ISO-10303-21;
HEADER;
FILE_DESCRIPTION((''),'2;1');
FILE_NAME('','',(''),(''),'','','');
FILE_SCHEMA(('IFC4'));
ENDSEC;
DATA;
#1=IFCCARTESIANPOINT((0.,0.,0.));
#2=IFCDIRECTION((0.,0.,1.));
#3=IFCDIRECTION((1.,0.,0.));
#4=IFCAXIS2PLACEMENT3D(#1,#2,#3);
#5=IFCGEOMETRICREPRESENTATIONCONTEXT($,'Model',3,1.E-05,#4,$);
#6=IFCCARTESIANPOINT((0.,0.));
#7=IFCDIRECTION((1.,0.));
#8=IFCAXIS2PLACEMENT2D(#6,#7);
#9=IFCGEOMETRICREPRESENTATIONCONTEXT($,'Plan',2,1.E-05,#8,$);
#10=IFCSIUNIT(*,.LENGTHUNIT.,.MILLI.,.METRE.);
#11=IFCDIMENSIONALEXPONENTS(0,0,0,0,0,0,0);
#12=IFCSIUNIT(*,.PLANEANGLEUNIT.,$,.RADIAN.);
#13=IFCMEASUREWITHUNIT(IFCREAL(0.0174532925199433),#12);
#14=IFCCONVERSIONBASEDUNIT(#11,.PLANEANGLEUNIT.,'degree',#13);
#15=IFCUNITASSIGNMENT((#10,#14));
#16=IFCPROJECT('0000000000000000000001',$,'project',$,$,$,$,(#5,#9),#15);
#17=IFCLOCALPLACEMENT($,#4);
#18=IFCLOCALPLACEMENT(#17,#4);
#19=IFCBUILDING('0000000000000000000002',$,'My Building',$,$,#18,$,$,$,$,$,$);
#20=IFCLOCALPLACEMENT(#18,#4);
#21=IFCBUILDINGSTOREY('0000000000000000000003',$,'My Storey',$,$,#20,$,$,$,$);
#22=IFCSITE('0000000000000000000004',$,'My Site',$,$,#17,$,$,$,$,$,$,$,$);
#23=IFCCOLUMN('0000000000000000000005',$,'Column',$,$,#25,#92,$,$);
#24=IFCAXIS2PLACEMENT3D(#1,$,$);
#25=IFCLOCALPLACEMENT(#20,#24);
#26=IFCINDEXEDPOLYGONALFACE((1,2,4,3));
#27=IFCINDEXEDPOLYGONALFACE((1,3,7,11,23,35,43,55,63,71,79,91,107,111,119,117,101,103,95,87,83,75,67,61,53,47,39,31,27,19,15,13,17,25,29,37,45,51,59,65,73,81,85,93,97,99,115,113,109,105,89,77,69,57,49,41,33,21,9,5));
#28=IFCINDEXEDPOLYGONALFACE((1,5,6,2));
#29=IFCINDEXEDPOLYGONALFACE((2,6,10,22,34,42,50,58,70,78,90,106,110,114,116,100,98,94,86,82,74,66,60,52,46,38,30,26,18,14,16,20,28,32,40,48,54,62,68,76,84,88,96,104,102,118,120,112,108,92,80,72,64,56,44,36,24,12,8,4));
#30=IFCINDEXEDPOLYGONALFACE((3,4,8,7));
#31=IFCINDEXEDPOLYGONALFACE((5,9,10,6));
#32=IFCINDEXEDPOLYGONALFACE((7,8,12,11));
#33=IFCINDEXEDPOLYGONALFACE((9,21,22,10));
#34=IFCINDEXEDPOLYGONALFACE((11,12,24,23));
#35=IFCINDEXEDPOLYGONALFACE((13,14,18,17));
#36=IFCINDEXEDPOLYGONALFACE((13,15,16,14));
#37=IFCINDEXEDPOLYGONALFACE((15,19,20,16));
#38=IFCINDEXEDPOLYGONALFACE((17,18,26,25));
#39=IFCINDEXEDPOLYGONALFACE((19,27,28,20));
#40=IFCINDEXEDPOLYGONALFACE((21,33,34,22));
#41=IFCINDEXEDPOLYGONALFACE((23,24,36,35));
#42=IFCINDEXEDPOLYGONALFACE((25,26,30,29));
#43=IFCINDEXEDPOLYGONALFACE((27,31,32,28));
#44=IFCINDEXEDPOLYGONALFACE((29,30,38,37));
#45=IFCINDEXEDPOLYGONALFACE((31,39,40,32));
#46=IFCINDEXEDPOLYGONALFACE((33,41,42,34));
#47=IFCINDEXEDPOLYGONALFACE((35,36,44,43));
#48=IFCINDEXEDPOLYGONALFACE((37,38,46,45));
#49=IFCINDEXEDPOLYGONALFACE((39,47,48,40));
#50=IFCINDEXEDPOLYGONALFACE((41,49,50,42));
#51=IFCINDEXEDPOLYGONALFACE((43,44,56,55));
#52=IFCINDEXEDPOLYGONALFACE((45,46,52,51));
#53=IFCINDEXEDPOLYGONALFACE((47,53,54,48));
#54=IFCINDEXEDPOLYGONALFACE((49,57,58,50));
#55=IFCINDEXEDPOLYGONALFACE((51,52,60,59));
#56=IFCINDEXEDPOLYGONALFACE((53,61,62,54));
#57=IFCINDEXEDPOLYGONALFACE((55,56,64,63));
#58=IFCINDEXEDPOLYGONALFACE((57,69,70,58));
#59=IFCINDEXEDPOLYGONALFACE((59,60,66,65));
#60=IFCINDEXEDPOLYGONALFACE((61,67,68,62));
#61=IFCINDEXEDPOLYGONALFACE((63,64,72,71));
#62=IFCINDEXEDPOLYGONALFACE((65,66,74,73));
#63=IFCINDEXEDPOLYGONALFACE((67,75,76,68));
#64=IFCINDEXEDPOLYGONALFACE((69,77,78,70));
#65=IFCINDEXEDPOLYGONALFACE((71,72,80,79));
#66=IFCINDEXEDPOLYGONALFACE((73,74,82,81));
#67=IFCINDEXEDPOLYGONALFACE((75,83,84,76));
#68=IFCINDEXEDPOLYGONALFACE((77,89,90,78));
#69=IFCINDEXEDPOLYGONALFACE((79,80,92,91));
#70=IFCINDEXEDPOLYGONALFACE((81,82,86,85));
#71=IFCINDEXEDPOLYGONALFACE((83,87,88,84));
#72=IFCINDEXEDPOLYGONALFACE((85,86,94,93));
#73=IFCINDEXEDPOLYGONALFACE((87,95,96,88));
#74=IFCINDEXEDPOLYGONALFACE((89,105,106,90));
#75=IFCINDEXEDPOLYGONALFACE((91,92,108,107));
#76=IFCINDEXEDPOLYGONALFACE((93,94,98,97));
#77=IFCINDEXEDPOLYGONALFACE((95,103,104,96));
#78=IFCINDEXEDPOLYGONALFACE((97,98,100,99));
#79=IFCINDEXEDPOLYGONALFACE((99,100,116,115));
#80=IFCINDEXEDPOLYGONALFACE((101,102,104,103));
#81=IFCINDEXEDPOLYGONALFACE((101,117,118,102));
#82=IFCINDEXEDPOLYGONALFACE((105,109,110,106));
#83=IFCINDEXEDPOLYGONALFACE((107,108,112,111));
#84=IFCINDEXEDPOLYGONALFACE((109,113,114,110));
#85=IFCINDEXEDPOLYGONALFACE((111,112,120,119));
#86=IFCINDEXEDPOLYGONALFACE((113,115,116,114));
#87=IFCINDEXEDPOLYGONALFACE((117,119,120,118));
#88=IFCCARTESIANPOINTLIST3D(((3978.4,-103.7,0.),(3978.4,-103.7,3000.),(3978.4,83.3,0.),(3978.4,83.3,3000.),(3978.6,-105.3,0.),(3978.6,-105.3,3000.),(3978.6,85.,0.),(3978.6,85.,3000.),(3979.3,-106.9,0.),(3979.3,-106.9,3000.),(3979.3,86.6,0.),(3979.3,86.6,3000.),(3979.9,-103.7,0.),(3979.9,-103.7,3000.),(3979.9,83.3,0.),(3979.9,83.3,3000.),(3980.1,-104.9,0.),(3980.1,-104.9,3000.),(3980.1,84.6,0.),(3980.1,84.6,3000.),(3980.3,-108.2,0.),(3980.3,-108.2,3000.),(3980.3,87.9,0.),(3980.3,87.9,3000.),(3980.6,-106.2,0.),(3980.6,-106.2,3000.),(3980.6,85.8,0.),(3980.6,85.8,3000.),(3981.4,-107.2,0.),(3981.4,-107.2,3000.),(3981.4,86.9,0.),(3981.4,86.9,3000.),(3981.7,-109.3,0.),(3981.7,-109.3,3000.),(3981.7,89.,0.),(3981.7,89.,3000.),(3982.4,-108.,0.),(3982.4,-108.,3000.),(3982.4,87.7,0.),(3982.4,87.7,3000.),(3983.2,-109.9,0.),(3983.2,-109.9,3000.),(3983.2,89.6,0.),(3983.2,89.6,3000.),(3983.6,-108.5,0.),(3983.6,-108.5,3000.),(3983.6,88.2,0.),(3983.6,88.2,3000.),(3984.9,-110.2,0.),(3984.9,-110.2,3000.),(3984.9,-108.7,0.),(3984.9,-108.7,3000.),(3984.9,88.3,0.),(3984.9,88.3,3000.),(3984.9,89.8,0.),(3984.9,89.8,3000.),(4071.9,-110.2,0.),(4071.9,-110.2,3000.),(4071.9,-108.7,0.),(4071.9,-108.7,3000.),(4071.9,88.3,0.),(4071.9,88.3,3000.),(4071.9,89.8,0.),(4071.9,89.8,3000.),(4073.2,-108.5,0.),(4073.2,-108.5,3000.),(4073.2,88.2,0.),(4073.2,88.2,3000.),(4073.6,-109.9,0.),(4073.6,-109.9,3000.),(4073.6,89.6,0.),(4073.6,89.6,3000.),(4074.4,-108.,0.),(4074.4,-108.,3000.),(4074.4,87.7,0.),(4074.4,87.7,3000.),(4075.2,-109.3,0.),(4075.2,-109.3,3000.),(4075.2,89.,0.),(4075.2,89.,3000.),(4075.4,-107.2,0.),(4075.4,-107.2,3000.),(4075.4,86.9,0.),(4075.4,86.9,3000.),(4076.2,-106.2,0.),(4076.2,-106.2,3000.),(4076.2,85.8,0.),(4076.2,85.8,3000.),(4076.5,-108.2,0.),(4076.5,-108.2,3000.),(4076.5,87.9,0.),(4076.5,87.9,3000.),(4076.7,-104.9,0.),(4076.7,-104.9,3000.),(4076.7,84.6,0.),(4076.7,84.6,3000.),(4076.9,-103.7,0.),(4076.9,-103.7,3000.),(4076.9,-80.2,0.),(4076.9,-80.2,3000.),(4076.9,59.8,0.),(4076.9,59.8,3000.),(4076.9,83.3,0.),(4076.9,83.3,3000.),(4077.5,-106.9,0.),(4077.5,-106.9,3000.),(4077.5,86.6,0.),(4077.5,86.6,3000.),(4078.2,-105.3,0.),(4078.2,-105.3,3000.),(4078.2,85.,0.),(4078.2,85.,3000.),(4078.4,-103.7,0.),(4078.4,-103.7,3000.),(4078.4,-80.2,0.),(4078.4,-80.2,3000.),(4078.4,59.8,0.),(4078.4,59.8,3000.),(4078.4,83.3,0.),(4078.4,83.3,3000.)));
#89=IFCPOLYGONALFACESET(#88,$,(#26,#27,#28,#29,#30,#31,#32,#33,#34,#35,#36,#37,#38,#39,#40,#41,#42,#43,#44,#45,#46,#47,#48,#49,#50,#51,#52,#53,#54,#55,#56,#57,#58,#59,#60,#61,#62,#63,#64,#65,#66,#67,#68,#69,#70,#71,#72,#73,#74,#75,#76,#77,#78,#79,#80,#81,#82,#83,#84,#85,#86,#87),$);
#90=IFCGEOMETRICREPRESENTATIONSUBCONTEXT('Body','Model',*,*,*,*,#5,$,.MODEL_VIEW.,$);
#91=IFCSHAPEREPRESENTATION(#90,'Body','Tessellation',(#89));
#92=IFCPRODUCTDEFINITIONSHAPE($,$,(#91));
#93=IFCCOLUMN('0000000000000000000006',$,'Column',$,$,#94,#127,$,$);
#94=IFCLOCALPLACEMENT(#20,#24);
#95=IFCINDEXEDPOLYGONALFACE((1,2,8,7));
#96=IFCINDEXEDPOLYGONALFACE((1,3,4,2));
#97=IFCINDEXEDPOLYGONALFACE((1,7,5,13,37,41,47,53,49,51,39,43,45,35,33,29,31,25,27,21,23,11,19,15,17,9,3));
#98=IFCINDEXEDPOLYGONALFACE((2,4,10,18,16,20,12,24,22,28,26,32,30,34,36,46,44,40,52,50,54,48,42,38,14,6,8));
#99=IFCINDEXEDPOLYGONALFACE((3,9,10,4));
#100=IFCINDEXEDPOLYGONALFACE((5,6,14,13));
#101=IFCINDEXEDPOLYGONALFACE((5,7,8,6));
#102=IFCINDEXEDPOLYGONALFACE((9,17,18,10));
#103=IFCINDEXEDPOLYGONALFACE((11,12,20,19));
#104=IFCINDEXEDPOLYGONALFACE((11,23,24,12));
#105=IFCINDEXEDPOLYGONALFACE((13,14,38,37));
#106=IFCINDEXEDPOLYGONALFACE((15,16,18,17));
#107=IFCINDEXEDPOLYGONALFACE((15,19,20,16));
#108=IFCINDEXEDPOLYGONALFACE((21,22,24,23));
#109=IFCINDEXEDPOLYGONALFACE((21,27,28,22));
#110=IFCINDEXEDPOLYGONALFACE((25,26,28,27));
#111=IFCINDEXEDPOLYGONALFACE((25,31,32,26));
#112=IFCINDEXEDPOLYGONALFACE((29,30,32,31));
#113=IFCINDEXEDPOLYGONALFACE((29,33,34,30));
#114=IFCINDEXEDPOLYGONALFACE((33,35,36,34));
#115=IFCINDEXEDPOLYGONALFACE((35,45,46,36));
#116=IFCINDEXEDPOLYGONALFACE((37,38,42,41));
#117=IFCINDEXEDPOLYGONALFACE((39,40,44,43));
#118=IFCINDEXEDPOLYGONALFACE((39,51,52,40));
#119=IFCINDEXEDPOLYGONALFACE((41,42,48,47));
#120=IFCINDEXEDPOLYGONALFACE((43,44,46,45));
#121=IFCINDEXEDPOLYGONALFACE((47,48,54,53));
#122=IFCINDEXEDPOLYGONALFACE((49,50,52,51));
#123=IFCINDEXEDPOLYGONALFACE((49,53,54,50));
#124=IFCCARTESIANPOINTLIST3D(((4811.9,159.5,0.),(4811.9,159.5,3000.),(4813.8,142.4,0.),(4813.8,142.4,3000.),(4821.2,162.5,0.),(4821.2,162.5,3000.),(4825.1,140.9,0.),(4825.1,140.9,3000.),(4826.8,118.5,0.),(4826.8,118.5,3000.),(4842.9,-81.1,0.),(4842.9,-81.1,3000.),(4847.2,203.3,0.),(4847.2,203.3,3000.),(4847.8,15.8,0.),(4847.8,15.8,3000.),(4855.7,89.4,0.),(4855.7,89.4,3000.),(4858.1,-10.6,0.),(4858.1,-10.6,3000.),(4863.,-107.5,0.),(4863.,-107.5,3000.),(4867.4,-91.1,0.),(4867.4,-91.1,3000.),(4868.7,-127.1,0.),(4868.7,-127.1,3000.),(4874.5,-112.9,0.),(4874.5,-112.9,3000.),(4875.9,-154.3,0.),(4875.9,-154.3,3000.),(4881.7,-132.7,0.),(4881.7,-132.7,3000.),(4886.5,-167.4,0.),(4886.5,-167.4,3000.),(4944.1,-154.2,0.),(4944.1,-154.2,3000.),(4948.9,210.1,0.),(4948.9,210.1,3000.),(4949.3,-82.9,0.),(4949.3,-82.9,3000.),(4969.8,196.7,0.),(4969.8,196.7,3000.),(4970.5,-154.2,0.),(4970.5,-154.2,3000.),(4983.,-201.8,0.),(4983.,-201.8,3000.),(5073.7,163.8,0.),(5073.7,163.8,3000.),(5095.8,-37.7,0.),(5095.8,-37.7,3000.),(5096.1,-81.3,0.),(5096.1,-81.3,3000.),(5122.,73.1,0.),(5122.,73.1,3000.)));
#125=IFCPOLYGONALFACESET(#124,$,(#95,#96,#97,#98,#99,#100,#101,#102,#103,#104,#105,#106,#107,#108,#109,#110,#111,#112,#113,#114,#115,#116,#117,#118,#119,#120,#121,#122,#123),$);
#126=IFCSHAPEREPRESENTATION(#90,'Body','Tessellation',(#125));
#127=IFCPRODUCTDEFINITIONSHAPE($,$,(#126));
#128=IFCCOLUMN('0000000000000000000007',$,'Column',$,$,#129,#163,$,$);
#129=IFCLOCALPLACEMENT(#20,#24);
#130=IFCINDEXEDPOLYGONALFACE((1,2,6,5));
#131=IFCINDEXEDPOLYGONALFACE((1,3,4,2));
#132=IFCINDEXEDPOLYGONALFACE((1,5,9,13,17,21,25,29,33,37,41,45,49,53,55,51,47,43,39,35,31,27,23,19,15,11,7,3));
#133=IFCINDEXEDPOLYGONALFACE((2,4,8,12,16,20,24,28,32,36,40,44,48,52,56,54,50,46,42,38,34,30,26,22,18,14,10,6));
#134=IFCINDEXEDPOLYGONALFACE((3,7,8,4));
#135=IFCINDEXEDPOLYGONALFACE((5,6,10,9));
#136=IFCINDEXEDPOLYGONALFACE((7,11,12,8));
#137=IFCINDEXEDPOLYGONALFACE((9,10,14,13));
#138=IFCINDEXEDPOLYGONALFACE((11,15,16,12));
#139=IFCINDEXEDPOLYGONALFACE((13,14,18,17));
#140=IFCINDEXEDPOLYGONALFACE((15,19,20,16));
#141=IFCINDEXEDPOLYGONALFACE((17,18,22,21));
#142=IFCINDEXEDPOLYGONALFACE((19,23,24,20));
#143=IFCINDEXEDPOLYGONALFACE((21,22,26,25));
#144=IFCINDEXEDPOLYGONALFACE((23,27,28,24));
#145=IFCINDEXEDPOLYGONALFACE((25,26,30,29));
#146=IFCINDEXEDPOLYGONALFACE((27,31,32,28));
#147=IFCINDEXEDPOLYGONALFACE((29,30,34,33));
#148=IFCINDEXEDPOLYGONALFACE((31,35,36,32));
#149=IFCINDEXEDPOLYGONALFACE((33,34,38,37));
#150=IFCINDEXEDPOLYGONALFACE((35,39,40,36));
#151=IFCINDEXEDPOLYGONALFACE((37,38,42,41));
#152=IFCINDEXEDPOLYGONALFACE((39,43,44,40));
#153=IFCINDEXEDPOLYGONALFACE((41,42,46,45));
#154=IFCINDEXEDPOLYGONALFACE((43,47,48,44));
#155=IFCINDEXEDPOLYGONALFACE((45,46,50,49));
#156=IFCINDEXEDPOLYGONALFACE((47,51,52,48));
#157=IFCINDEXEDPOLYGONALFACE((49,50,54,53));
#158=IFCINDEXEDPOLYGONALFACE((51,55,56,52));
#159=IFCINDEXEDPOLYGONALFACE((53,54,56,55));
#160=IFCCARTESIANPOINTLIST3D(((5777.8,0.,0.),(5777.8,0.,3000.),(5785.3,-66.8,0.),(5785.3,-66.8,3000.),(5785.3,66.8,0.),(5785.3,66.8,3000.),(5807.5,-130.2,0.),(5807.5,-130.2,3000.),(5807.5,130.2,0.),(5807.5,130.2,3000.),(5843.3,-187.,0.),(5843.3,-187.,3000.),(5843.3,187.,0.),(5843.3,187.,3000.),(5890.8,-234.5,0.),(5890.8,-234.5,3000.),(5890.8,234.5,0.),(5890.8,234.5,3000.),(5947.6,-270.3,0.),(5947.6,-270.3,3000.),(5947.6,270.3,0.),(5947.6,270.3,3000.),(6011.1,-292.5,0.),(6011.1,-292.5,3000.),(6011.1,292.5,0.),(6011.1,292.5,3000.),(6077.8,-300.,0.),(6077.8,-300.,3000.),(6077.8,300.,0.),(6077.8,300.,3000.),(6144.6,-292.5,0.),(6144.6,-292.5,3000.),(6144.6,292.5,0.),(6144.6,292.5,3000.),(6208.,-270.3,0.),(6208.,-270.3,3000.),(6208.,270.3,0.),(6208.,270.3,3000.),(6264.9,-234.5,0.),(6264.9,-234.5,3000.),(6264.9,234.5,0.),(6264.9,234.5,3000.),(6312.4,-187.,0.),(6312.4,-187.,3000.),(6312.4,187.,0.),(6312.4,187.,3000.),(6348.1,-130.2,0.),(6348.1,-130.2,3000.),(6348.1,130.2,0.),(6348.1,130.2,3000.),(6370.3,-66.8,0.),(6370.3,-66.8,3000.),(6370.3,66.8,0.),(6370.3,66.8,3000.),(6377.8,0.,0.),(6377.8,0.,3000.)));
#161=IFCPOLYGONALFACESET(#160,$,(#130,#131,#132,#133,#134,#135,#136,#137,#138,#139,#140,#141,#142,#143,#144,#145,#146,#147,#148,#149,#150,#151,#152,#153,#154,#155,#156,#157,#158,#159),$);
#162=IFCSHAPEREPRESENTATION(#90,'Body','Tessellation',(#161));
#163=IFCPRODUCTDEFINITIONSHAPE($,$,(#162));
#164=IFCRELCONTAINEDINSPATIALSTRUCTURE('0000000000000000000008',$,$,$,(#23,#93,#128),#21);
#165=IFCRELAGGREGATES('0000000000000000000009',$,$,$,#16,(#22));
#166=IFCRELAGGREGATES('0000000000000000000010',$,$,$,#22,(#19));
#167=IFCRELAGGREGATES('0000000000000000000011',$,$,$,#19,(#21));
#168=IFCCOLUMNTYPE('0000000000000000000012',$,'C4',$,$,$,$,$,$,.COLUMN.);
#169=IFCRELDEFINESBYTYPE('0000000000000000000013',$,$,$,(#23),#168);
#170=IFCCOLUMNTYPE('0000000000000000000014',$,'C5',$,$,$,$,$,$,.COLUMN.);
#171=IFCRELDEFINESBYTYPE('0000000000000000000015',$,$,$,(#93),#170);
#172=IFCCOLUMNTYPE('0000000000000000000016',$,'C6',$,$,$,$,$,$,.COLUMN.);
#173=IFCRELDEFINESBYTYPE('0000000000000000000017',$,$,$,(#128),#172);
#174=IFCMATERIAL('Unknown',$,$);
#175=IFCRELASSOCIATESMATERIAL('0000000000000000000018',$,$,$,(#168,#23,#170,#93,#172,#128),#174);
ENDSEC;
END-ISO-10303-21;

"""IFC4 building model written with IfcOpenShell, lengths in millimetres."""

from ifc_helpers import new_model, entity, si_unit, converted_unit, frame, origin_with_axes, origin_2d_with_axis, place, context, subcontext, project, spatial, line, indexed_curve, circle, c_section, outline, extrude, material, material_profile, profile_set, profile_usage, type_object, element, save


model = new_model("IFC4")

# Units and contexts
model_context = context("Model", 3, precision=1e-05, world=origin_with_axes())
plan_context = context("Plan", 2, precision=1e-05, world=origin_2d_with_axis())
body_context = subcontext(model_context, "Body", "Model", "MODEL_VIEW")
ifc_project = project(units=[si_unit("LENGTHUNIT", "METRE", prefix="MILLI"), converted_unit("PLANEANGLEUNIT", "degree", entity("IfcReal", 0.0174532925199433), si_unit("PLANEANGLEUNIT", "RADIAN"), dimensions=[0, 0, 0, 0, 0, 0, 0])], contexts=[model_context, plan_context])

# Site, building, storey
site_placement = place(None, origin_with_axes())
site = spatial("IfcSite", under=ifc_project, at=site_placement, Name="My Site")
building_placement = place(site_placement, origin_with_axes())
building = spatial("IfcBuilding", under=site, at=building_placement, Name="My Building")
storey_placement = place(building_placement, origin_with_axes())
storey = spatial("IfcBuildingStorey", under=building, at=storey_placement, Name="My Storey")

# Columns
ifc_material = material(Name="Unknown")
ifc_material_profile_1 = material_profile(ifc_material, c_section(Depth=200.0, Width=100.0, WallThickness=1.5, Girth=30.0, InternalFilletRadius=5.0))
ifc_profile_set_1 = profile_set([ifc_material_profile_1])
ifc_profile_usage_1 = profile_usage(ifc_profile_set_1)
column_type_1 = type_object("IfcColumnType", Name="C4", PredefinedType="COLUMN", material=ifc_profile_set_1)
column_1_placement = place(storey_placement, frame((4028.4, -10.2, 0.0), z_axis=(0.0, 0.0, 1.0), x_axis=(1.0, 0.0, 0.0)))
element("IfcColumn", 1, at=column_1_placement, inside=storey, type_object=column_type_1, material=ifc_profile_usage_1, Name="Column", context=body_context, shape_type="SweptSolid", body=[
    extrude(c_section(Depth=200.0, Width=100.0, WallThickness=1.5, Girth=30.0, InternalFilletRadius=5.0), origin_with_axes(), (0.0, 0.0, 1.0), 3000.0),
])
ifc_material_profile_2 = material_profile(ifc_material, outline(indexed_curve([(-33.1, 5.7), (-22.6, -7.3), (35.1, 5.8), (74.0, -41.8), (61.5, 5.8), (40.2, 77.1), (187.0, 78.7), (212.9, 233.1), (164.7, 323.8), (60.7, 356.7), (39.8, 370.1), (-61.9, 363.3), (-87.9, 322.5), (-82.3, 278.5), (-53.4, 249.5), (-61.3, 175.9), (-51.0, 149.4), (-66.1, 78.9), (-41.7, 68.9), (-46.1, 52.5), (-34.6, 47.1), (-40.3, 32.9), (-27.4, 27.3), (-84.0, 300.9), (-95.3, 302.4), (-97.2, 319.5), (186.8, 122.3)], segments=[line(25, 26), line(26, 24), line(24, 13), line(13, 12), line(12, 11), line(11, 10), line(10, 9), line(9, 8), line(8, 27), line(27, 7), line(7, 6), line(6, 5), line(5, 4), line(4, 3), line(3, 2), line(2, 1), line(1, 23), line(23, 22), line(22, 21), line(21, 20), line(20, 19), line(19, 18), line(18, 17), line(17, 16), line(16, 15), line(15, 14), line(14, 25)], self_intersect=False)))
ifc_profile_set_2 = profile_set([ifc_material_profile_2])
ifc_profile_usage_2 = profile_usage(ifc_profile_set_2)
column_type_2 = type_object("IfcColumnType", Name="C5", PredefinedType="COLUMN", material=ifc_profile_set_2)
column_2_placement = place(storey_placement, frame((4909.1, -160.0, 0.0), z_axis=(0.0, 0.0, 1.0), x_axis=(1.0, 0.0, 0.0)))
element("IfcColumn", 2, at=column_2_placement, inside=storey, type_object=column_type_2, material=ifc_profile_usage_2, Name="Column", context=body_context, shape_type="SweptSolid", body=[
    extrude(outline(indexed_curve([(-33.1, 5.7), (-22.6, -7.3), (35.1, 5.8), (74.0, -41.8), (61.5, 5.8), (40.2, 77.1), (187.0, 78.7), (212.9, 233.1), (164.7, 323.8), (60.7, 356.7), (39.8, 370.1), (-61.9, 363.3), (-87.9, 322.5), (-82.3, 278.5), (-53.4, 249.5), (-61.3, 175.9), (-51.0, 149.4), (-66.1, 78.9), (-41.7, 68.9), (-46.1, 52.5), (-34.6, 47.1), (-40.3, 32.9), (-27.4, 27.3), (-84.0, 300.9), (-95.3, 302.4), (-97.2, 319.5), (186.8, 122.3)], segments=[line(25, 26), line(26, 24), line(24, 13), line(13, 12), line(12, 11), line(11, 10), line(10, 9), line(9, 8), line(8, 27), line(27, 7), line(7, 6), line(6, 5), line(5, 4), line(4, 3), line(3, 2), line(2, 1), line(1, 23), line(23, 22), line(22, 21), line(21, 20), line(20, 19), line(19, 18), line(18, 17), line(17, 16), line(16, 15), line(15, 14), line(14, 25)], self_intersect=False)), origin_with_axes(), (0.0, 0.0, 1.0), 3000.0),
])
ifc_material_profile_3 = material_profile(ifc_material, circle(Radius=300.0))
ifc_profile_set_3 = profile_set([ifc_material_profile_3])
ifc_profile_usage_3 = profile_usage(ifc_profile_set_3)
column_type_3 = type_object("IfcColumnType", Name="C6", PredefinedType="COLUMN", material=ifc_profile_set_3)
column_3_placement = place(storey_placement, frame((6077.8, 0.0, 0.0), z_axis=(0.0, 0.0, 1.0), x_axis=(1.0, 0.0, 0.0)))
element("IfcColumn", 3, at=column_3_placement, inside=storey, type_object=column_type_3, material=ifc_profile_usage_3, Name="Column", context=body_context, shape_type="SweptSolid", body=[
    extrude(circle(Radius=300.0), origin_with_axes(), (0.0, 0.0, 1.0), 3000.0),
])

save(model, "model.ifc")
